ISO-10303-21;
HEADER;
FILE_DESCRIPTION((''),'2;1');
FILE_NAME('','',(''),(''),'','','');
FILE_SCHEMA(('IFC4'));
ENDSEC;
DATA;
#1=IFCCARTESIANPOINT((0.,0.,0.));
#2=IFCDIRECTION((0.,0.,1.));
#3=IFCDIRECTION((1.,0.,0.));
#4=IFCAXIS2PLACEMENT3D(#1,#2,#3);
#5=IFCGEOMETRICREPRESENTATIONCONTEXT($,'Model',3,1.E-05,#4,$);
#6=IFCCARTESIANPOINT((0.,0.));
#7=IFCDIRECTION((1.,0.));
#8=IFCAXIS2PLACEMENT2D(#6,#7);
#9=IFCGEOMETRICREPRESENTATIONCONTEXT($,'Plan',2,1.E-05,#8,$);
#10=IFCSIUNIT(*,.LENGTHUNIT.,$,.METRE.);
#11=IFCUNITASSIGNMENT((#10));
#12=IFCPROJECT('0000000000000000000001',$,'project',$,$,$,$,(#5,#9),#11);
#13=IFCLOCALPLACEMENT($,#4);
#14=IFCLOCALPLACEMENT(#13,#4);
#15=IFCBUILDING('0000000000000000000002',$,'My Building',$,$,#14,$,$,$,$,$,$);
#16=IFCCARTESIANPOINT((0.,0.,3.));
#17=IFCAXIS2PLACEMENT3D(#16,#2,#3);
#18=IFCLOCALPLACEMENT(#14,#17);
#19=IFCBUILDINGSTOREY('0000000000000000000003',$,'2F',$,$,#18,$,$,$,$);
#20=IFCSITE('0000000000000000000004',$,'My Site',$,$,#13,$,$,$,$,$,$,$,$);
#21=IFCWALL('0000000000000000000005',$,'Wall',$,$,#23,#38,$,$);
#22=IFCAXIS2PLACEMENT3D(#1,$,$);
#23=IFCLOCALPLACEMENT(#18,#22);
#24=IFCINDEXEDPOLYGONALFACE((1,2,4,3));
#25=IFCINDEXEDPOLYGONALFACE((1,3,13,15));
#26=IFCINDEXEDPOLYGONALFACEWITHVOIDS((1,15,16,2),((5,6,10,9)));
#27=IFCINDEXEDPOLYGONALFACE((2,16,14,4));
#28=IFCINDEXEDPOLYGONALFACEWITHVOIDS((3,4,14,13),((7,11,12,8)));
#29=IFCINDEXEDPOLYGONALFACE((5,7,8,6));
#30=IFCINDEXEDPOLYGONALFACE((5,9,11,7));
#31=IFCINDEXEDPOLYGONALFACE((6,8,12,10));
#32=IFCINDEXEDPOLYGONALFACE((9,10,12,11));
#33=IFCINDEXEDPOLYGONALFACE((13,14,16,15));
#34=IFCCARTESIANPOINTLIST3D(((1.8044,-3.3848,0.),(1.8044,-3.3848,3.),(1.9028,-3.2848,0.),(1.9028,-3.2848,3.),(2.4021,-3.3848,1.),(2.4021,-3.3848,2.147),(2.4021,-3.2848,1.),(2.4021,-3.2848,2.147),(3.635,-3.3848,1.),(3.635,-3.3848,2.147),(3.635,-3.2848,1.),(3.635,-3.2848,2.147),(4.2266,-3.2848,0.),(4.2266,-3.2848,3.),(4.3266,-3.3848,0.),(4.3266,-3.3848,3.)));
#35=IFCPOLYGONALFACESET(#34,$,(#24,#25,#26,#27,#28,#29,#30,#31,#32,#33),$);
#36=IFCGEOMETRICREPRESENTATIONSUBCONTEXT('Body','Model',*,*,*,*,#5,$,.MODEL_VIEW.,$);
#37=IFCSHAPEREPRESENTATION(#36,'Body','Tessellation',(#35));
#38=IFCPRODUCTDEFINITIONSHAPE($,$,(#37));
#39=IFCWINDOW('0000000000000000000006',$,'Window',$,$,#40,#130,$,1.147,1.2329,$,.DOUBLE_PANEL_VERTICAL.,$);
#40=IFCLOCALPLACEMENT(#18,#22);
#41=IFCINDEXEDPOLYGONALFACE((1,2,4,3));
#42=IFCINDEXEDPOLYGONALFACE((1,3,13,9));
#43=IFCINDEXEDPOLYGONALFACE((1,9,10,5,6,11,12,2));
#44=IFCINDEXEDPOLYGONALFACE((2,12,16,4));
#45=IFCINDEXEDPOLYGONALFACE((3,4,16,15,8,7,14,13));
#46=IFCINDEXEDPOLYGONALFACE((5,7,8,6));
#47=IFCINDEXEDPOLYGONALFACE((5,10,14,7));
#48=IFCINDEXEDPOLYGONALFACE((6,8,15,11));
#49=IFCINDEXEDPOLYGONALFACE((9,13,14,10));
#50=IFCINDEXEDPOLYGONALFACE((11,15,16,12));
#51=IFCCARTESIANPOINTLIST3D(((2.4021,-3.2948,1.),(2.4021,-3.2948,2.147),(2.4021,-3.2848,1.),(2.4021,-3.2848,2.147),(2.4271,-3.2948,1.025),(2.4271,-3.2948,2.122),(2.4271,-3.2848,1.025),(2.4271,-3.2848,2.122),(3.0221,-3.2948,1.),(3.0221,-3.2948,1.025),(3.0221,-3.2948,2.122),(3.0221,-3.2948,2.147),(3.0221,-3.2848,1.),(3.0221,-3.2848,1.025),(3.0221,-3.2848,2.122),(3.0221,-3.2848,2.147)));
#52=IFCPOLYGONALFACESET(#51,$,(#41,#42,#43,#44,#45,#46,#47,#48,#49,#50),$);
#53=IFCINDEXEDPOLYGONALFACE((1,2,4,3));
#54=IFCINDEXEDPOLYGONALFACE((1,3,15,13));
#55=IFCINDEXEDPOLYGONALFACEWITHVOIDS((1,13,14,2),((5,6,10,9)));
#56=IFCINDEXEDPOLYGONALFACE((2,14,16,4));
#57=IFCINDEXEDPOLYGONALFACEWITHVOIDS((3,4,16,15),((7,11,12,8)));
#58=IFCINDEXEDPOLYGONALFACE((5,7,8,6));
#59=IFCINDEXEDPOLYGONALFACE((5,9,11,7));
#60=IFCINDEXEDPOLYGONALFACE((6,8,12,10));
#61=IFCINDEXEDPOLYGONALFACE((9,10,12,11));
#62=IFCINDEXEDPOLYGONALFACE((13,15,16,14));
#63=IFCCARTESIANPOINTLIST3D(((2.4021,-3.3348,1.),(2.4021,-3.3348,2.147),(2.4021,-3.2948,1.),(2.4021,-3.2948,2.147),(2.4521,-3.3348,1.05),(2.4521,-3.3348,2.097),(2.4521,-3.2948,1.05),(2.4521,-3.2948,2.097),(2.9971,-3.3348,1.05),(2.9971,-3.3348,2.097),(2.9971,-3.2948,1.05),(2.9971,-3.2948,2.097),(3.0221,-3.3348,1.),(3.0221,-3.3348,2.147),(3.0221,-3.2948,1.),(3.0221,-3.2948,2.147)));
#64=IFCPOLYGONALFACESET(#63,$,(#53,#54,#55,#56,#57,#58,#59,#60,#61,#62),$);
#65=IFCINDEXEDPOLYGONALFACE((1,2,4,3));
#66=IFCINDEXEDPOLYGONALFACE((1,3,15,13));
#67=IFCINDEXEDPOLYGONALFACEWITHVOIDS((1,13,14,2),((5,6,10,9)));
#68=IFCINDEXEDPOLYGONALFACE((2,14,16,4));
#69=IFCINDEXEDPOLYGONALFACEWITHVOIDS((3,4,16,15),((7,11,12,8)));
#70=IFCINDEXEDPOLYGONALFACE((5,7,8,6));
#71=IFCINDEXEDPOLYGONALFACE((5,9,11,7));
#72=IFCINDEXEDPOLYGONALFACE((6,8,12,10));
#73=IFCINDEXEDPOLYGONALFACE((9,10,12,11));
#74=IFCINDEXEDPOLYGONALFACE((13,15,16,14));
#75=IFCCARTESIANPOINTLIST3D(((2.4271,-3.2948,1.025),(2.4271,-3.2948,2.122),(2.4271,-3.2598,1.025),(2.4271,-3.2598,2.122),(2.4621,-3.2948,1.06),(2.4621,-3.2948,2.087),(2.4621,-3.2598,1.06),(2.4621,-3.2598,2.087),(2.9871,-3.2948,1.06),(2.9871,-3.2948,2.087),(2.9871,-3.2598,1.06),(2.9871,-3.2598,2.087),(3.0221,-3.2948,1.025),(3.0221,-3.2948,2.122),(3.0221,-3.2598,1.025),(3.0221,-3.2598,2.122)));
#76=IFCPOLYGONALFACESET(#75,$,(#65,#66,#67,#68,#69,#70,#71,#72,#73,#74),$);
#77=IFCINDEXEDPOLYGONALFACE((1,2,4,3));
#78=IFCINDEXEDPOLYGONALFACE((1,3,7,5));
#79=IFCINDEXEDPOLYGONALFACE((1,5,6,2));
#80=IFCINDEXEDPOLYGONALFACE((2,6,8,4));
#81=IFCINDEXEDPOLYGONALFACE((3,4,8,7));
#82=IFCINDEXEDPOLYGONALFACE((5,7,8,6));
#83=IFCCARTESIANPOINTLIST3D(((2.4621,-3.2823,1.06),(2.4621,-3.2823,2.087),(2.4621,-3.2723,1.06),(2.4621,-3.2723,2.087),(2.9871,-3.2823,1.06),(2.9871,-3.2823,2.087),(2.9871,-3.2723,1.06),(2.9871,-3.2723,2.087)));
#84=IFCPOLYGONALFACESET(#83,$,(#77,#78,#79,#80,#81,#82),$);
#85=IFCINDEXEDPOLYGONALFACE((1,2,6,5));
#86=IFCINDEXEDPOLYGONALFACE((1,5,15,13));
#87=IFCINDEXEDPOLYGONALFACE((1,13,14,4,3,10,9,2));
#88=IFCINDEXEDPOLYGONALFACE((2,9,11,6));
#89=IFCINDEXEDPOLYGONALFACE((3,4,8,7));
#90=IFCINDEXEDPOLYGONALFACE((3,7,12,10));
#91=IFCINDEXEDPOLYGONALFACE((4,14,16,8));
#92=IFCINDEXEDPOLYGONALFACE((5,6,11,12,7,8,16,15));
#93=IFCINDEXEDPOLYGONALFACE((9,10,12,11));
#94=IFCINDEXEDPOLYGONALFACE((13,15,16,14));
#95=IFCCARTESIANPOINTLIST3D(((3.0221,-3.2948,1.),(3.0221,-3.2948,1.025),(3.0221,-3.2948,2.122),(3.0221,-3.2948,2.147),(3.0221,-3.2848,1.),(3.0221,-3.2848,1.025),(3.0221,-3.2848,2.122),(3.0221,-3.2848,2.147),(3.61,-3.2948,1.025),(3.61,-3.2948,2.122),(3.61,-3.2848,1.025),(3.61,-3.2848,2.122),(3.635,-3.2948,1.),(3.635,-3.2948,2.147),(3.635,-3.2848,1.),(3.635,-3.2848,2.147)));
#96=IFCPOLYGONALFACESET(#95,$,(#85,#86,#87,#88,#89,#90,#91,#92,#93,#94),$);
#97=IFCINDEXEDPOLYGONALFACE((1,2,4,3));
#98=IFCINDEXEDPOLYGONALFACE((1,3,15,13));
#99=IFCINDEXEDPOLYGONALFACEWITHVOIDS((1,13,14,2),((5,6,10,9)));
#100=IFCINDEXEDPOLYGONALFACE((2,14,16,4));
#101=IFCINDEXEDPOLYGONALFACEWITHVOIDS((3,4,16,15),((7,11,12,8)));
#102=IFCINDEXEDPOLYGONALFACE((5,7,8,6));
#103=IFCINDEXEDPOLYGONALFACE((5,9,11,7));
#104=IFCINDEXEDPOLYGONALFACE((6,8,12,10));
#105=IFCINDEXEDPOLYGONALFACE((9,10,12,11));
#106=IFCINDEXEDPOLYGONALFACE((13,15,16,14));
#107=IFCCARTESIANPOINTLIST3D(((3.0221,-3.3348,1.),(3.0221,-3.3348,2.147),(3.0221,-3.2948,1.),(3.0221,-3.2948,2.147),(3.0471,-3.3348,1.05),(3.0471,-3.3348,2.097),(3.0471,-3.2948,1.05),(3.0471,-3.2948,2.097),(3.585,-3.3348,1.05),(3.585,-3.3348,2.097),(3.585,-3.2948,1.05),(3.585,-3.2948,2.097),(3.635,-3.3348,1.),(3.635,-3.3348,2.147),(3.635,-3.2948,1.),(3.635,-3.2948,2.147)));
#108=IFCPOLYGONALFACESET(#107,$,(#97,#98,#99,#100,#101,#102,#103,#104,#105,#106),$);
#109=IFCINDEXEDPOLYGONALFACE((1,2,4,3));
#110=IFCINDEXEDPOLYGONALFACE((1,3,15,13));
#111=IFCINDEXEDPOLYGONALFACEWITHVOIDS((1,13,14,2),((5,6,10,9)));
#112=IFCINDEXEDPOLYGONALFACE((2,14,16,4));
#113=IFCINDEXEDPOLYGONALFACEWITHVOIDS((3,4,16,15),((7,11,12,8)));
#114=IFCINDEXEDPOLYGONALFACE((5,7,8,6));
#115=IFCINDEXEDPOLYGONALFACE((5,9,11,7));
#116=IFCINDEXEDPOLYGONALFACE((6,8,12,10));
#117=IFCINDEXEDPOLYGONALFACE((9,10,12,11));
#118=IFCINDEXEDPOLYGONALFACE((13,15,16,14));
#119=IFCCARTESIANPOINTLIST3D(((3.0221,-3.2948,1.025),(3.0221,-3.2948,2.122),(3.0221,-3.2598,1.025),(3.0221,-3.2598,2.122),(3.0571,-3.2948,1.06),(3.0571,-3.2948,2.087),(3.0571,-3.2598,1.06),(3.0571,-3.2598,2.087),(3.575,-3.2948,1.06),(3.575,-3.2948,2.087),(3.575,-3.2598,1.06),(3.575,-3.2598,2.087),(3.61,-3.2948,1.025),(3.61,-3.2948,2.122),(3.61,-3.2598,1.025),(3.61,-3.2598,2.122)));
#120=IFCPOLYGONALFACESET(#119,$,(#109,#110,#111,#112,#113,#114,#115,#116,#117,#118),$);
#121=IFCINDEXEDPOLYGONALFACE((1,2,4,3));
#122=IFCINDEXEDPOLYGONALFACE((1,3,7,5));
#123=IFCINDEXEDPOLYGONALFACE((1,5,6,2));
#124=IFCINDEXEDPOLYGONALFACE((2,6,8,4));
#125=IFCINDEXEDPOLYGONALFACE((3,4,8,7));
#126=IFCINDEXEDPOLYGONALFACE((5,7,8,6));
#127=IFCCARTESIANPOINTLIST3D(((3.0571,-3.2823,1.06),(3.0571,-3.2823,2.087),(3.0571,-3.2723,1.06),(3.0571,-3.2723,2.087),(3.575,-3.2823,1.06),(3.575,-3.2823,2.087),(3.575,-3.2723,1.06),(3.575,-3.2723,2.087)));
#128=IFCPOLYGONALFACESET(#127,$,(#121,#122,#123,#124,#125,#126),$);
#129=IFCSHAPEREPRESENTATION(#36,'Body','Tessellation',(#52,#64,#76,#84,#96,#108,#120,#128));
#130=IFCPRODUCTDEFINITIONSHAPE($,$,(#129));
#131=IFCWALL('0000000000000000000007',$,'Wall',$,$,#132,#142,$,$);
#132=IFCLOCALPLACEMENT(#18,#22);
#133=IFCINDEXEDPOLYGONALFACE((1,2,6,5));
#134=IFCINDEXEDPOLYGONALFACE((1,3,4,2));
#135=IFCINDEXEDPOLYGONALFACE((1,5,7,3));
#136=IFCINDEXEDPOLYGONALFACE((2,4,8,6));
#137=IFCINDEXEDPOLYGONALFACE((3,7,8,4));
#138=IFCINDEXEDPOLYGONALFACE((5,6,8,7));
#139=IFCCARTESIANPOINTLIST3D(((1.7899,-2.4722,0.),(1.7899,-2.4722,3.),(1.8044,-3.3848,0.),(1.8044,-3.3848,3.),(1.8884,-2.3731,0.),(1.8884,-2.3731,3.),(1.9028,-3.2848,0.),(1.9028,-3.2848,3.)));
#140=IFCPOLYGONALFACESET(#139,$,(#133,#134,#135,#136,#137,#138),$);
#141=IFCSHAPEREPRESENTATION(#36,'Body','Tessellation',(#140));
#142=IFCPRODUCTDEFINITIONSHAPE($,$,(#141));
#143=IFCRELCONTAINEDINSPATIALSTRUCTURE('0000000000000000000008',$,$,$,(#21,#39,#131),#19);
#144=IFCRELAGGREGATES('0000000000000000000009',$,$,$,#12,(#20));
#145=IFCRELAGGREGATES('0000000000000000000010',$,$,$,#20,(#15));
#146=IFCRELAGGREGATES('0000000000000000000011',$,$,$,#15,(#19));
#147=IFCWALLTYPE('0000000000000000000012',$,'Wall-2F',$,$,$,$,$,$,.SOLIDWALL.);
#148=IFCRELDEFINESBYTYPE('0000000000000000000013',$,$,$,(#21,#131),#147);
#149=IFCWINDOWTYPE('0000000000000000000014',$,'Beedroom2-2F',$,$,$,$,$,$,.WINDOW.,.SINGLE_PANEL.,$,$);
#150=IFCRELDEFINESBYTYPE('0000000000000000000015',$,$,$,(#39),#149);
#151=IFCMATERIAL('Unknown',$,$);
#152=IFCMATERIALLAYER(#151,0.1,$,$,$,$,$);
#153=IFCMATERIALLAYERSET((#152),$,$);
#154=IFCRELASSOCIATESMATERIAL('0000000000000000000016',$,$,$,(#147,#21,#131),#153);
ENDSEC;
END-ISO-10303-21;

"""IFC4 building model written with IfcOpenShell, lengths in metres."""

from ifc_helpers import new_model, entity, si_unit, frame, origin_with_axes, origin_2d_with_axis, place, context, subcontext, project, spatial, line, indexed_curve, outline, extrude, shape, source, transform, mapped, material, layer, layer_set, layer_usage, type_object, type_shapes, element, fill, save


model = new_model("IFC4")

# Units and contexts
model_context = context("Model", 3, precision=1e-05, world=origin_with_axes())
plan_context = context("Plan", 2, precision=1e-05, world=origin_2d_with_axis())
body_context_1 = subcontext(model_context, "Body", "Model", "MODEL_VIEW")
body_context_2 = subcontext(plan_context, "Body", "Plan", "PLAN_VIEW")
ifc_project = project(units=[si_unit("LENGTHUNIT", "METRE")], contexts=[model_context, plan_context])

# Site, building, storey
site_placement = place(None, origin_with_axes())
site = spatial("IfcSite", under=ifc_project, at=site_placement, Name="My Site")
building_placement = place(site_placement, origin_with_axes())
building = spatial("IfcBuilding", under=site, at=building_placement, Name="My Building")
storey_placement = place(building_placement, frame((0.0, 0.0, 3.0), z_axis=(0.0, 0.0, 1.0), x_axis=(1.0, 0.0, 0.0)))
storey = spatial("IfcBuildingStorey", under=building, at=storey_placement, Name="2F")

# Shared definitions
ifc_material = material(Name="Unknown")

# Shared definitions
ifc_layer_1 = layer(ifc_material, 0.1)
ifc_layer_set_1 = layer_set([ifc_layer_1])
wall_type = type_object("IfcWallType", Name="Wall-2F", PredefinedType="SOLIDWALL", material=ifc_layer_set_1)

# Wall, opening, window
ifc_layer_usage_1 = layer_usage(ifc_layer_set_1, "AXIS2", "POSITIVE", 0.0)
wall_1_placement = place(storey_placement, frame((4.2266, -3.2848, 0.0), z_axis=(0.0, 0.0, 1.0), x_axis=(-1.0, 0.0, 0.0)))
wall_1 = element("IfcWall", 1, at=wall_1_placement, inside=storey, type_object=wall_type, material=ifc_layer_usage_1, Name="Wall", context=body_context_1, shape_type="SweptSolid", body=[
    extrude(outline(indexed_curve([(0.0, 0.0), (-0.1, 0.1), (2.4222, 0.1), (2.3238, 0.0)], segments=[line(1, 2, 3, 4, 1)])), origin_with_axes(), (0.0, 0.0, 1.0), 3.0),
])
shared_shape_1 = source(origin_with_axes(), body_context_1, "Body", "SweptSolid", [
    extrude(outline(indexed_curve([(0.0, 0.0), (1.2329, 0.0), (1.2329, 1.147), (0.0, 1.147)], segments=[line(1, 2, 3, 4, 1)])), frame((0.0, -0.6, 0.0), z_axis=(0.0, -1.0, 0.0), x_axis=(1.0, 0.0, 0.0)), (0.0, 0.0, -1.0), 1.2),
])
opening_1_placement = place(wall_1_placement, frame((1.8245, 0.1, 1.0), z_axis=(0.0, 0.0, 1.0), x_axis=(-1.0, 0.0, 0.0)))
opening_1 = element("IfcOpeningElement", 2, at=opening_1_placement, cuts=wall_1, PredefinedType="OPENING", context=body_context_1, shape_type="MappedRepresentation", body=[
    mapped(shared_shape_1, transform((0.0, 0.0, 0.0), x_axis=(1.0, 0.0, 0.0), y_axis=(0.0, 1.0, 0.0), z_axis=(0.0, 0.0, 1.0), scale=1.0)),
])
window_type_1 = type_object("IfcWindowType", Name="Beedroom2-2F", PartitioningType="SINGLE_PANEL", PredefinedType="WINDOW")
shared_shape_2 = source(origin_with_axes(), body_context_1, "Body", "SweptSolid", [
    extrude(outline(indexed_curve([(0.6201, 0.0), (0.0, 0.0), (0.0, 1.147), (0.6201, 1.147), (0.6201, 1.122), (0.025, 1.122), (0.025, 0.025), (0.6201, 0.025)], segments=[line(1, 2, 3, 4, 5, 6, 7, 8, 1)])), frame((0.0, 0.09, 0.0), z_axis=(0.0, -1.0, 0.0), x_axis=(1.0, 0.0, 0.0)), (0.0, 0.0, -1.0), 0.01),
    extrude(outline(indexed_curve([(0.0, 0.0), (0.6201, 0.0), (0.6201, 1.147), (0.0, 1.147)], segments=[line(1, 2, 3, 4, 1)]), holes=[indexed_curve([(0.05, 0.05), (0.5951, 0.05), (0.5951, 1.097), (0.05, 1.097)], segments=[line(1, 2, 3, 4, 1)])]), frame((0.0, 0.05, 0.0), z_axis=(0.0, -1.0, 0.0), x_axis=(1.0, 0.0, 0.0)), (0.0, 0.0, -1.0), 0.04),
    extrude(outline(indexed_curve([(0.0, 0.0), (0.5951, 0.0), (0.5951, 1.097), (0.0, 1.097)], segments=[line(1, 2, 3, 4, 1)]), holes=[indexed_curve([(0.035, 0.035), (0.5601, 0.035), (0.5601, 1.062), (0.035, 1.062)], segments=[line(1, 2, 3, 4, 1)])]), frame((0.025, 0.09, 0.025), z_axis=(0.0, -1.0, 0.0), x_axis=(1.0, 0.0, 0.0)), (0.0, 0.0, -1.0), 0.035),
    extrude(outline(indexed_curve([(0.035, 0.035), (0.5601, 0.035), (0.5601, 1.062), (0.035, 1.062)], segments=[line(1, 2, 3, 4, 1)])), frame((0.025, 0.1025, 0.025), z_axis=(0.0, -1.0, 0.0), x_axis=(1.0, 0.0, 0.0)), (0.0, 0.0, -1.0), 0.01),
    extrude(outline(indexed_curve([(0.0, 1.147), (0.6128, 1.147), (0.6128, 0.0), (0.0, 0.0), (0.0, 0.025), (0.5878, 0.025), (0.5878, 1.122), (0.0, 1.122)], segments=[line(1, 2, 3, 4, 5, 6, 7, 8, 1)])), frame((0.6201, 0.09, 0.0), z_axis=(0.0, -1.0, 0.0), x_axis=(1.0, 0.0, 0.0)), (0.0, 0.0, -1.0), 0.01),
    extrude(outline(indexed_curve([(0.0, 0.0), (0.6128, 0.0), (0.6128, 1.147), (0.0, 1.147)], segments=[line(1, 2, 3, 4, 1)]), holes=[indexed_curve([(0.025, 0.05), (0.5628, 0.05), (0.5628, 1.097), (0.025, 1.097)], segments=[line(1, 2, 3, 4, 1)])]), frame((0.6201, 0.05, 0.0), z_axis=(0.0, -1.0, 0.0), x_axis=(1.0, 0.0, 0.0)), (0.0, 0.0, -1.0), 0.04),
    extrude(outline(indexed_curve([(0.0, 0.0), (0.5878, 0.0), (0.5878, 1.097), (0.0, 1.097)], segments=[line(1, 2, 3, 4, 1)]), holes=[indexed_curve([(0.035, 0.035), (0.5528, 0.035), (0.5528, 1.062), (0.035, 1.062)], segments=[line(1, 2, 3, 4, 1)])]), frame((0.6201, 0.09, 0.025), z_axis=(0.0, -1.0, 0.0), x_axis=(1.0, 0.0, 0.0)), (0.0, 0.0, -1.0), 0.035),
    extrude(outline(indexed_curve([(0.035, 0.035), (0.5528, 0.035), (0.5528, 1.062), (0.035, 1.062)], segments=[line(1, 2, 3, 4, 1)])), frame((0.6201, 0.1025, 0.025), z_axis=(0.0, -1.0, 0.0), x_axis=(1.0, 0.0, 0.0)), (0.0, 0.0, -1.0), 0.01),
])
shared_shape_3 = source(origin_with_axes(), body_context_2, "Body", "Curve2D", [
    entity("IfcIndexedPolyCurve", entity("IfcCartesianPointList2D", [[0.05, 0.05], [0.5951, 0.05]])),
    entity("IfcIndexedPolyCurve", entity("IfcCartesianPointList2D", [[0.0, 0.1], [0.025, 0.1], [0.025, 0.09], [0.05, 0.09], [0.05, 0.05], [0.0, 0.05]]), [entity("IfcLineIndex", [1, 2, 3, 4, 5, 6, 1])]),
    entity("IfcIndexedPolyCurve", entity("IfcCartesianPointList2D", [[0.6201, 0.1], [0.6201, 0.1], [0.6201, 0.09], [0.5951, 0.09], [0.5951, 0.05], [0.6201, 0.05]])),
    entity("IfcIndexedPolyCurve", entity("IfcCartesianPointList2D", [[0.025, 0.09], [0.06, 0.09], [0.06, 0.125], [0.025, 0.125]]), [entity("IfcLineIndex", [1, 2, 3, 4, 1])]),
    entity("IfcIndexedPolyCurve", entity("IfcCartesianPointList2D", [[0.6201, 0.09], [0.5851, 0.09], [0.5851, 0.125], [0.6201, 0.125]]), [entity("IfcLineIndex", [1, 2, 3, 4, 1])]),
    entity("IfcIndexedPolyCurve", entity("IfcCartesianPointList2D", [[0.06, 0.09], [0.5851, 0.09]])),
    entity("IfcIndexedPolyCurve", entity("IfcCartesianPointList2D", [[0.06, 0.125], [0.5851, 0.125]])),
    entity("IfcIndexedPolyCurve", entity("IfcCartesianPointList2D", [[0.06, 0.1075], [0.5851, 0.1075]])),
    entity("IfcIndexedPolyCurve", entity("IfcCartesianPointList2D", [[0.6451, 0.05], [1.1829, 0.05]])),
    entity("IfcIndexedPolyCurve", entity("IfcCartesianPointList2D", [[0.6201, 0.1], [0.6201, 0.1], [0.6201, 0.09], [0.6451, 0.09], [0.6451, 0.05], [0.6201, 0.05]])),
    entity("IfcIndexedPolyCurve", entity("IfcCartesianPointList2D", [[1.2329, 0.1], [1.2079, 0.1], [1.2079, 0.09], [1.1829, 0.09], [1.1829, 0.05], [1.2329, 0.05]]), [entity("IfcLineIndex", [1, 2, 3, 4, 5, 6, 1])]),
    entity("IfcIndexedPolyCurve", entity("IfcCartesianPointList2D", [[0.6201, 0.09], [0.6551, 0.09], [0.6551, 0.125], [0.6201, 0.125]]), [entity("IfcLineIndex", [1, 2, 3, 4, 1])]),
    entity("IfcIndexedPolyCurve", entity("IfcCartesianPointList2D", [[1.2079, 0.09], [1.1729, 0.09], [1.1729, 0.125], [1.2079, 0.125]]), [entity("IfcLineIndex", [1, 2, 3, 4, 1])]),
    entity("IfcIndexedPolyCurve", entity("IfcCartesianPointList2D", [[0.6551, 0.09], [1.1729, 0.09]])),
    entity("IfcIndexedPolyCurve", entity("IfcCartesianPointList2D", [[0.6551, 0.125], [1.1729, 0.125]])),
    entity("IfcIndexedPolyCurve", entity("IfcCartesianPointList2D", [[0.6551, 0.1075], [1.1729, 0.1075]])),
])
type_shapes(window_type_1, [shared_shape_2, shared_shape_3])
window_1_placement = place(opening_1_placement, origin_with_axes())
window_1 = element("IfcWindow", 3, at=window_1_placement, inside=storey, type_object=window_type_1, Name="Window", OverallHeight=1.147, OverallWidth=1.2329, PartitioningType="DOUBLE_PANEL_VERTICAL", shapes=[
    shape(body_context_1, "Body", "MappedRepresentation", [mapped(shared_shape_2, transform((0.0, 0.0, 0.0), x_axis=(1.0, 0.0, 0.0), y_axis=(0.0, 1.0, 0.0), z_axis=(0.0, 0.0, 1.0), scale=1.0))]),
    shape(body_context_2, "Body", "MappedRepresentation", [mapped(shared_shape_3, transform((0.0, 0.0, 0.0), x_axis=(1.0, 0.0, 0.0), y_axis=(0.0, 1.0, 0.0), z_axis=(0.0, 0.0, 1.0), scale=1.0))]),
])
fill(opening_1, window_1)

# Wall
ifc_layer_usage_2 = layer_usage(ifc_layer_set_1, "AXIS2", "POSITIVE", 0.0)
wall_2_placement = place(storey_placement, frame((1.9028, -3.2848, 0.0), z_axis=(0.0, 0.0, 1.0), x_axis=(-0.015871, 0.999874, 0.0)))
element("IfcWall", 4, at=wall_2_placement, inside=storey, type_object=wall_type, material=ifc_layer_usage_2, Name="Wall", context=body_context_1, shape_type="SweptSolid", body=[
    extrude(outline(indexed_curve([(0.0, 0.0), (-0.0984, 0.1), (0.8143, 0.1), (0.9117, 0.0)], segments=[line(1, 2, 3, 4, 1)])), origin_with_axes(), (0.0, 0.0, 1.0), 3.0),
])

save(model, "model.ifc")
